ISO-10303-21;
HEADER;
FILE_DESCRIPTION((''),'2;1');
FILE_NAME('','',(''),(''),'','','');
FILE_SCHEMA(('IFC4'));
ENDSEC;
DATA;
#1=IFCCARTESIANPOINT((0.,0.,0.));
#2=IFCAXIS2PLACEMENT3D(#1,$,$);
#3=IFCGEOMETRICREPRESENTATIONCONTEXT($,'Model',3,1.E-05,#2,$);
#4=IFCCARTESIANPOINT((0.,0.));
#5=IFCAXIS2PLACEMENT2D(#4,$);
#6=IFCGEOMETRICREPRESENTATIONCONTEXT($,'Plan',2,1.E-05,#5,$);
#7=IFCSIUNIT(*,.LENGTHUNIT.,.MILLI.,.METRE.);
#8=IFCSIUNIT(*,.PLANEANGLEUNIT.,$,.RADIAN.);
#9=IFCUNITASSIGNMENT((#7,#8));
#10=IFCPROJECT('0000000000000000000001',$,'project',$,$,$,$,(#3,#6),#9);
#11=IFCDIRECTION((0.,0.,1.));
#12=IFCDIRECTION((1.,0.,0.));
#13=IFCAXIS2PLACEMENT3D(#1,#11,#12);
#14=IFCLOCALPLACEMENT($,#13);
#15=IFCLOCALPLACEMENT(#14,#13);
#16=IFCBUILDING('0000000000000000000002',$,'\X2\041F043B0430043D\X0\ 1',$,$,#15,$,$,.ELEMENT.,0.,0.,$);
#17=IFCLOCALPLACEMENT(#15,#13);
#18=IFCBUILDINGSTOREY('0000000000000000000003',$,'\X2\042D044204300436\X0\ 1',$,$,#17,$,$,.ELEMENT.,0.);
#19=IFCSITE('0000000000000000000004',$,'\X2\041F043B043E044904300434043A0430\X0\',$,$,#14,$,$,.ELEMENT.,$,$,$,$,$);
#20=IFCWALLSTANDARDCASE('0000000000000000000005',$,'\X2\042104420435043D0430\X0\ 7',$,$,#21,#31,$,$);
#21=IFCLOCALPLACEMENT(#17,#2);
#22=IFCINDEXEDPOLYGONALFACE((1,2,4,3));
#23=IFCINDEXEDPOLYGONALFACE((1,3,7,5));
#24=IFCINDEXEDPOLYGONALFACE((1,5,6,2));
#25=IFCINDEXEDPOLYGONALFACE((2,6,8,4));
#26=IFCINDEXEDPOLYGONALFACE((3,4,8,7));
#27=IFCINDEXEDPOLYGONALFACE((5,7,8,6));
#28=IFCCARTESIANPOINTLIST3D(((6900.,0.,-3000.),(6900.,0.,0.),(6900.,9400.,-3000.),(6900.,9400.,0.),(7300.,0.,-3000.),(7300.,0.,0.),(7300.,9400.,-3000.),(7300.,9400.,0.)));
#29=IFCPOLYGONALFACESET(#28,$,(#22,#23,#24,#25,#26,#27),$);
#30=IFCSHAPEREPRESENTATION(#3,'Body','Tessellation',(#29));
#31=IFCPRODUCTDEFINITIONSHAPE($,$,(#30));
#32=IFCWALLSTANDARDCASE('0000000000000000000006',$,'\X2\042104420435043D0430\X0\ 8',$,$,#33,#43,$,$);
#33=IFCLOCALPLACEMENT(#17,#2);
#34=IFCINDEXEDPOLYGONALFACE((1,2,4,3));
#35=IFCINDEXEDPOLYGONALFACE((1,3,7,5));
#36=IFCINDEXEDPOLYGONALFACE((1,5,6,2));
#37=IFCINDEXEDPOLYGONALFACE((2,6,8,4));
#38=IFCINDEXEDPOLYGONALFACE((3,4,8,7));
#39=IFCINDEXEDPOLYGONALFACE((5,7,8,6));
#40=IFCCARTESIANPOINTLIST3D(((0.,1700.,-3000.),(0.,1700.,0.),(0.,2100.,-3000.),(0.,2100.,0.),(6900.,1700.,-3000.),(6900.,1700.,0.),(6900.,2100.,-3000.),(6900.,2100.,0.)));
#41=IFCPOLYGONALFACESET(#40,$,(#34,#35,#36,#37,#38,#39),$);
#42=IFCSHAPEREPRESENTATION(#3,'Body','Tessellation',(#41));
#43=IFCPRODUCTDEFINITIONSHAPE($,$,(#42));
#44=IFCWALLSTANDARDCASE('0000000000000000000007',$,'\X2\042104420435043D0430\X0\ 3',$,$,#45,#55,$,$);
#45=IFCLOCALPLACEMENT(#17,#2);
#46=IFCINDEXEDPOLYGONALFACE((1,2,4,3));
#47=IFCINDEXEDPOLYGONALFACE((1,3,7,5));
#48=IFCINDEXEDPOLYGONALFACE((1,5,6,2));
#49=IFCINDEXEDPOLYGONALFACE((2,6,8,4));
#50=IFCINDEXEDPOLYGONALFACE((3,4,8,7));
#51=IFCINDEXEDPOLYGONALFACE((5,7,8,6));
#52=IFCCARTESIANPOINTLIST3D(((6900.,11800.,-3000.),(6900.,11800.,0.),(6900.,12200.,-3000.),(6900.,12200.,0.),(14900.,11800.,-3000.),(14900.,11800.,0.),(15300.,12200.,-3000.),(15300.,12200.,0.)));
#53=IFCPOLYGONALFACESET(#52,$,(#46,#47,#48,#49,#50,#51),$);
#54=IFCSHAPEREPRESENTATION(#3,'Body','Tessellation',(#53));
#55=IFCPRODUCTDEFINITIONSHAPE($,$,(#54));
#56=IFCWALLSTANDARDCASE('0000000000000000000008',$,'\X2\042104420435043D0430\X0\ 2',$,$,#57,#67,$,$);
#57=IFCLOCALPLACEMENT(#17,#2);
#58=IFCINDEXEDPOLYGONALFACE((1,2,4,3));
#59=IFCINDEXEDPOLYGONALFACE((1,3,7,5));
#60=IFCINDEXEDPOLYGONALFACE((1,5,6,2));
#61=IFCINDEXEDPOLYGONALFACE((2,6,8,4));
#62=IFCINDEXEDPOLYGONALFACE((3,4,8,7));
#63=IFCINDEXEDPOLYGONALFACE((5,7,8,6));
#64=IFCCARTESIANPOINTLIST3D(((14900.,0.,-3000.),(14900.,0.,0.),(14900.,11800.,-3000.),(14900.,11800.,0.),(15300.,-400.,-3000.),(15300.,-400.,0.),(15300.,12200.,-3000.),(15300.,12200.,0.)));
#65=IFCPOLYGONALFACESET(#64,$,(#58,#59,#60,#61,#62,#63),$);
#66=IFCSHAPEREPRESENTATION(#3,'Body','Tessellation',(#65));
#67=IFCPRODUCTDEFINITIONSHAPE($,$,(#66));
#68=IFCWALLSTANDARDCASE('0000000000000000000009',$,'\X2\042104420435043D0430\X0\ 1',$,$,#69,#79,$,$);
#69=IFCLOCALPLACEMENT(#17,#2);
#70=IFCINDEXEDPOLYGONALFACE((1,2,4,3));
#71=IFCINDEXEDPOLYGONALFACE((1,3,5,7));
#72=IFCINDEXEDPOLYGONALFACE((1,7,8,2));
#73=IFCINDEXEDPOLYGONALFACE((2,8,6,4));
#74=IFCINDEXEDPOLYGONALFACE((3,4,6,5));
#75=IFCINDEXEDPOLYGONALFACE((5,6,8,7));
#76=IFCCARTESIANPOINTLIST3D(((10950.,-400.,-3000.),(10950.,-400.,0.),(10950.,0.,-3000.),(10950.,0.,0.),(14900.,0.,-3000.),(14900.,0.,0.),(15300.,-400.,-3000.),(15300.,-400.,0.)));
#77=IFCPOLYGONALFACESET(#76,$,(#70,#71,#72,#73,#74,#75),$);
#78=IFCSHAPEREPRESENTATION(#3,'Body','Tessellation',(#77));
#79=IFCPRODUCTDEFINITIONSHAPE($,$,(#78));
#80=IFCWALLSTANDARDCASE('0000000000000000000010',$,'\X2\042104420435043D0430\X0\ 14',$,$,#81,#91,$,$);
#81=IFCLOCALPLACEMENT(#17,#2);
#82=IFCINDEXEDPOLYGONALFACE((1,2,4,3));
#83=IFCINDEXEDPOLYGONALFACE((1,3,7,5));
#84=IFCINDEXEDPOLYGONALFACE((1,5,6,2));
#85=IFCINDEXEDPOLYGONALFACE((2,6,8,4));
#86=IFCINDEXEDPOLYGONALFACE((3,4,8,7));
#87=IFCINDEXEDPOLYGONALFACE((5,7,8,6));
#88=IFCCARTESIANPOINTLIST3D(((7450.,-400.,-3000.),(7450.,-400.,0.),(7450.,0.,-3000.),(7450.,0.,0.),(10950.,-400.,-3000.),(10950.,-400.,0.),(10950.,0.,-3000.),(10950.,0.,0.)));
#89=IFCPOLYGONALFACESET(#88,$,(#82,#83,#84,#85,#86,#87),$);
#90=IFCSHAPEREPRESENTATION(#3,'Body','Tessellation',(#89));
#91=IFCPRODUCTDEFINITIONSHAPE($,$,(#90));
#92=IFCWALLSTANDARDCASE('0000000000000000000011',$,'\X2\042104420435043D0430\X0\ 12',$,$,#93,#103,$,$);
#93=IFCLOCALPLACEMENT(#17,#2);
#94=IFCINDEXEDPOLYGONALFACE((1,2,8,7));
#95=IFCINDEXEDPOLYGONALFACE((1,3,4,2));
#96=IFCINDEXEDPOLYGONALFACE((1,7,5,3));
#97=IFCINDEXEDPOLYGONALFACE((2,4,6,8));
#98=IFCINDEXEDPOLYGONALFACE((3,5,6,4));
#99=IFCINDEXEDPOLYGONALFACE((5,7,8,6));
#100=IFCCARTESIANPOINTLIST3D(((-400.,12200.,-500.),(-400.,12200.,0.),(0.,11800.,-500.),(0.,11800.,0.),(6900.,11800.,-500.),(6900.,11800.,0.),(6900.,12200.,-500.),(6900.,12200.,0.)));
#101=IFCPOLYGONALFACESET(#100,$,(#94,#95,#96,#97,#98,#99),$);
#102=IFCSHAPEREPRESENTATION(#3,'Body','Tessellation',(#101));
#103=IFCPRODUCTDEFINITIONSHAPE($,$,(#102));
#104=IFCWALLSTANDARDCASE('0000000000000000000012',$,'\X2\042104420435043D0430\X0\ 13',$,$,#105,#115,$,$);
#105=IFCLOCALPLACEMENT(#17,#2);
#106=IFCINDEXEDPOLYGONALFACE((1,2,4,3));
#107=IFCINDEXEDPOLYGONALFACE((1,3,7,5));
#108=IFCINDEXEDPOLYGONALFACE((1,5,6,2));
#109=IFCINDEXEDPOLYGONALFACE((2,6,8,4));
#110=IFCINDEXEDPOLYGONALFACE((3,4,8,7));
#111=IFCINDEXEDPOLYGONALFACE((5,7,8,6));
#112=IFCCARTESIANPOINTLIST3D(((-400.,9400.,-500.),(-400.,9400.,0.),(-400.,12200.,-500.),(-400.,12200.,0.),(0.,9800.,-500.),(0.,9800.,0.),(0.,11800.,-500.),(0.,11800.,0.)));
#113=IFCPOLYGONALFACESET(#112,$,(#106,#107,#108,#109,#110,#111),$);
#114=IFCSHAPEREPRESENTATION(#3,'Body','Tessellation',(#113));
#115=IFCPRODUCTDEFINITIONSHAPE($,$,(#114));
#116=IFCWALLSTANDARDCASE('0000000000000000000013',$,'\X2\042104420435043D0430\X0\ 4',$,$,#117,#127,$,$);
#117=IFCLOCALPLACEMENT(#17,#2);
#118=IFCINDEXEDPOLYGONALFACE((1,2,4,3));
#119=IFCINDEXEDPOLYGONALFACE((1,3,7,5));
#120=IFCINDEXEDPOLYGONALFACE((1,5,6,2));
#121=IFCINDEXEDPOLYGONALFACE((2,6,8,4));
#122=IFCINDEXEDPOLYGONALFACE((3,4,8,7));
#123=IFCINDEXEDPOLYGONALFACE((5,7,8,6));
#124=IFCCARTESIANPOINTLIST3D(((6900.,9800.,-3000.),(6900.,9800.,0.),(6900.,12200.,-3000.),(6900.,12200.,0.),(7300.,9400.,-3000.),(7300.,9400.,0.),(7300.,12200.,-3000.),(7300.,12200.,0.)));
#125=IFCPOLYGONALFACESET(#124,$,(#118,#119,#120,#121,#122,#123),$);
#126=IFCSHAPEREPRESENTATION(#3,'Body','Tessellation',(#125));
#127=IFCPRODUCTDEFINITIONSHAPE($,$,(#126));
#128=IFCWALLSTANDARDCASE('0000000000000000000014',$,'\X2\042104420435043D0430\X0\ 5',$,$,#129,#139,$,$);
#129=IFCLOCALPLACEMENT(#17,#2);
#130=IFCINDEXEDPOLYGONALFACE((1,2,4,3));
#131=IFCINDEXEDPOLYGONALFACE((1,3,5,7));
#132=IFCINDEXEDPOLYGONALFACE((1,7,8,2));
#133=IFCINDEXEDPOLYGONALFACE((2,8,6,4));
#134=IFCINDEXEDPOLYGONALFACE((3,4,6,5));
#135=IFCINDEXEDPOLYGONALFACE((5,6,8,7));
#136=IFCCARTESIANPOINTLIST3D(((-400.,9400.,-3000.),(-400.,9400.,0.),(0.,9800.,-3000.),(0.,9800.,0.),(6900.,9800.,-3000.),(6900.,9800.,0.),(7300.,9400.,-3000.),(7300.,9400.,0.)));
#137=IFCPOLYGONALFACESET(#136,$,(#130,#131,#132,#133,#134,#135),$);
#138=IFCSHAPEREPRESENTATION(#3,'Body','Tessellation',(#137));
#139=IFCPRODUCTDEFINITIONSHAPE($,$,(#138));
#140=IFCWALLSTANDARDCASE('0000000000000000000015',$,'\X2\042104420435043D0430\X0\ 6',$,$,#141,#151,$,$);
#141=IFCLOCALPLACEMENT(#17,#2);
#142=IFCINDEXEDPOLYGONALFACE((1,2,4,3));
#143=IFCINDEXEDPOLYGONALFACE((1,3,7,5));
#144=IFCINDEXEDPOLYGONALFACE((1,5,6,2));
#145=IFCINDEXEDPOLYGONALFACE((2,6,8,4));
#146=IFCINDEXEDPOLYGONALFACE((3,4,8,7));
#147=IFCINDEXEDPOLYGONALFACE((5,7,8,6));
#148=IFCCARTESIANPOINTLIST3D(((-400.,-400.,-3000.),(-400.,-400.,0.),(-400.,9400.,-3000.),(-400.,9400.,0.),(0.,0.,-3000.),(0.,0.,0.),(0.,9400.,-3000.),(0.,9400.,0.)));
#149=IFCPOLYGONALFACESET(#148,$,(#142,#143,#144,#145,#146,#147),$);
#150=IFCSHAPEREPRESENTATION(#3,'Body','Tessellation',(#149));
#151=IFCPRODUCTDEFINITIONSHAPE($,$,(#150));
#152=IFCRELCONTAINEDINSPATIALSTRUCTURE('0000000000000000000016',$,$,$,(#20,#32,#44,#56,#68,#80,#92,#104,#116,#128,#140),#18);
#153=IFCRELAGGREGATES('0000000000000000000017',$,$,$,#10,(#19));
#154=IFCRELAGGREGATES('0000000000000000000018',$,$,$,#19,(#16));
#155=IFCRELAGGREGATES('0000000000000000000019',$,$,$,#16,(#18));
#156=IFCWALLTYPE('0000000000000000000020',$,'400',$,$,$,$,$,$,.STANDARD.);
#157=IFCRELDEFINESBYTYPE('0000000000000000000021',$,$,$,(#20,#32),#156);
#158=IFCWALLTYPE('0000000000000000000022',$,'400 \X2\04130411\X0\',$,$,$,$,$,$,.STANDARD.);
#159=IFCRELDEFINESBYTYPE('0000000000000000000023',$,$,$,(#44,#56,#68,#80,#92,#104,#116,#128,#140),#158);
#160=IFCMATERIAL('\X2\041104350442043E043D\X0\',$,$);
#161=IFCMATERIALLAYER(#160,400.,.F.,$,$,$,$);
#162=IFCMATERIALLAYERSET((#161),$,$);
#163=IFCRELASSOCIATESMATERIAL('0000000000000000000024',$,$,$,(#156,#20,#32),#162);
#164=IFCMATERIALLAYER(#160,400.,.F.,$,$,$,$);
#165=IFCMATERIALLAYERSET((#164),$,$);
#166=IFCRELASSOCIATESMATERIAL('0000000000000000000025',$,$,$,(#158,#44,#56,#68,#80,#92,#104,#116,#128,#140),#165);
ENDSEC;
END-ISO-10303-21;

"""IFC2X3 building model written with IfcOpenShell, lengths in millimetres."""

from ifc_helpers import new_model, si_unit, frame, origin, origin_with_axes, origin_2d, place, context, project, spatial, polyline, segment, composite_curve, outline, extrude, material, layer, layer_set, layer_usage, type_object, element, save


model = new_model("IFC2X3")

# Units and contexts
model_context = context("Model", 3, precision=1e-05, world=origin())
plan_context = context("Plan", 2, precision=1e-05, world=origin_2d())
ifc_project = project(units=[si_unit("LENGTHUNIT", "METRE", prefix="MILLI"), si_unit("PLANEANGLEUNIT", "RADIAN")], contexts=[model_context, plan_context])

# Site, building, storey
site_placement = place(None, origin_with_axes())
site = spatial("IfcSite", under=ifc_project, at=site_placement, Name="Площадка", CompositionType="ELEMENT")
building_placement = place(site_placement, origin_with_axes())
building = spatial("IfcBuilding", under=site, at=building_placement, Name="План 1", CompositionType="ELEMENT", ElevationOfRefHeight=0.0, ElevationOfTerrain=0.0)
storey_placement = place(building_placement, origin_with_axes())
storey = spatial("IfcBuildingStorey", under=building, at=storey_placement, Name="Этаж 1", CompositionType="ELEMENT", Elevation=0.0)

# Walls
ifc_material = material(Name="Бетон")
ifc_layer_1 = layer(ifc_material, 400.0, ventilated=False)
ifc_layer_set_1 = layer_set([ifc_layer_1])
ifc_layer_usage_1 = layer_usage(ifc_layer_set_1, "AXIS2", "POSITIVE", -400.0)
wall_type_1 = type_object("IfcWallType", Name="400", PredefinedType="STANDARD", material=ifc_layer_set_1)
wall_1_placement = place(storey_placement, frame((6900.0, -400.0, -3000.0), z_axis=(0.0, 0.0, 1.0), x_axis=(0.0, 1.0, 0.0)))
element("IfcWallStandardCase", 1, at=wall_1_placement, inside=storey, type_object=wall_type_1, material=ifc_layer_usage_1, Name="Стена 7", context=model_context, shape_type="SweptSolid", body=[
    extrude(outline(composite_curve([segment(polyline([(400.0, 0.0), (400.0, -400.0)]), True, "CONTINUOUS"), segment(polyline([(400.0, -400.0), (9800.0, -400.0)]), True, "CONTINUOUS"), segment(polyline([(9800.0, -400.0), (9800.0, 0.0)]), True, "CONTINUOUS"), segment(polyline([(9800.0, 0.0), (400.0, 0.0)]), True, "CONTINUOUS")], self_intersect=False)), origin_with_axes(), (0.0, 0.0, 1.0), 3000.0),
])
ifc_layer_usage_2 = layer_usage(ifc_layer_set_1, "AXIS2", "POSITIVE", -400.0)
wall_2_placement = place(storey_placement, frame((-400.0, 2100.0, -3000.0), z_axis=(0.0, 0.0, 1.0), x_axis=(1.0, 0.0, 0.0)))
element("IfcWallStandardCase", 2, at=wall_2_placement, inside=storey, type_object=wall_type_1, material=ifc_layer_usage_2, Name="Стена 8", context=model_context, shape_type="SweptSolid", body=[
    extrude(outline(composite_curve([segment(polyline([(400.0, 0.0), (400.0, -400.0)]), True, "CONTINUOUS"), segment(polyline([(400.0, -400.0), (7300.0, -400.0)]), True, "CONTINUOUS"), segment(polyline([(7300.0, -400.0), (7300.0, 0.0)]), True, "CONTINUOUS"), segment(polyline([(7300.0, 0.0), (400.0, 0.0)]), True, "CONTINUOUS")], self_intersect=False)), origin_with_axes(), (0.0, 0.0, 1.0), 3000.0),
])
ifc_layer_2 = layer(ifc_material, 400.0, ventilated=False)
ifc_layer_set_2 = layer_set([ifc_layer_2])
ifc_layer_usage_3 = layer_usage(ifc_layer_set_2, "AXIS2", "POSITIVE", 0.0)
wall_type_2 = type_object("IfcWallType", Name="400 ГБ", PredefinedType="STANDARD", material=ifc_layer_set_2)
wall_3_placement = place(storey_placement, frame((15300.0, 12200.0, -3000.0), z_axis=(0.0, 0.0, 1.0), x_axis=(-1.0, 0.0, 0.0)))
element("IfcWallStandardCase", 3, at=wall_3_placement, inside=storey, type_object=wall_type_2, material=ifc_layer_usage_3, Name="Стена 3", context=model_context, shape_type="SweptSolid", body=[
    extrude(outline(composite_curve([segment(polyline([(400.0, 400.0), (0.0, 0.0)]), True, "CONTINUOUS"), segment(polyline([(0.0, 0.0), (8400.0, 0.0)]), True, "CONTINUOUS"), segment(polyline([(8400.0, 0.0), (8400.0, 400.0)]), True, "CONTINUOUS"), segment(polyline([(8400.0, 400.0), (400.0, 400.0)]), True, "CONTINUOUS")], self_intersect=False)), origin_with_axes(), (0.0, 0.0, 1.0), 3000.0),
])
ifc_layer_usage_4 = layer_usage(ifc_layer_set_2, "AXIS2", "POSITIVE", 0.0)
wall_4_placement = place(storey_placement, frame((15300.0, -400.0, -3000.0), z_axis=(0.0, 0.0, 1.0), x_axis=(0.0, 1.0, 0.0)))
element("IfcWallStandardCase", 4, at=wall_4_placement, inside=storey, type_object=wall_type_2, material=ifc_layer_usage_4, Name="Стена 2", context=model_context, shape_type="SweptSolid", body=[
    extrude(outline(composite_curve([segment(polyline([(400.0, 400.0), (0.0, 0.0)]), True, "CONTINUOUS"), segment(polyline([(0.0, 0.0), (12600.0, 0.0)]), True, "CONTINUOUS"), segment(polyline([(12600.0, 0.0), (12200.0, 400.0)]), True, "CONTINUOUS"), segment(polyline([(12200.0, 400.0), (400.0, 400.0)]), True, "CONTINUOUS")], self_intersect=False)), origin_with_axes(), (0.0, 0.0, 1.0), 3000.0),
])
ifc_layer_usage_5 = layer_usage(ifc_layer_set_2, "AXIS2", "POSITIVE", 0.0)
wall_5_placement = place(storey_placement, frame((10950.0, -400.0, -3000.0), z_axis=(0.0, 0.0, 1.0), x_axis=(1.0, 0.0, 0.0)))
element("IfcWallStandardCase", 5, at=wall_5_placement, inside=storey, type_object=wall_type_2, material=ifc_layer_usage_5, Name="Стена 1", context=model_context, shape_type="SweptSolid", body=[
    extrude(outline(composite_curve([segment(polyline([(0.0, 400.0), (0.0, 0.0)]), True, "CONTINUOUS"), segment(polyline([(0.0, 0.0), (4350.0, 0.0)]), True, "CONTINUOUS"), segment(polyline([(4350.0, 0.0), (3950.0, 400.0)]), True, "CONTINUOUS"), segment(polyline([(3950.0, 400.0), (0.0, 400.0)]), True, "CONTINUOUS")], self_intersect=False)), origin_with_axes(), (0.0, 0.0, 1.0), 3000.0),
])
ifc_layer_usage_6 = layer_usage(ifc_layer_set_2, "AXIS2", "POSITIVE", 0.0)
wall_6_placement = place(storey_placement, frame((7450.0, -400.0, -3000.0), z_axis=(0.0, 0.0, 1.0), x_axis=(1.0, 0.0, 0.0)))
element("IfcWallStandardCase", 6, at=wall_6_placement, inside=storey, type_object=wall_type_2, material=ifc_layer_usage_6, Name="Стена 14", context=model_context, shape_type="SweptSolid", body=[
    extrude(outline(composite_curve([segment(polyline([(0.0, 400.0), (0.0, 0.0)]), True, "CONTINUOUS"), segment(polyline([(0.0, 0.0), (3500.0, 0.0)]), True, "CONTINUOUS"), segment(polyline([(3500.0, 0.0), (3500.0, 400.0)]), True, "CONTINUOUS"), segment(polyline([(3500.0, 400.0), (0.0, 400.0)]), True, "CONTINUOUS")], self_intersect=False)), origin_with_axes(), (0.0, 0.0, 1.0), 3000.0),
])
ifc_layer_usage_7 = layer_usage(ifc_layer_set_2, "AXIS2", "POSITIVE", 0.0)
wall_7_placement = place(storey_placement, frame((6900.0, 12200.0, -500.0), z_axis=(0.0, 0.0, 1.0), x_axis=(-1.0, 0.0, 0.0)))
element("IfcWallStandardCase", 7, at=wall_7_placement, inside=storey, type_object=wall_type_2, material=ifc_layer_usage_7, Name="Стена 12", context=model_context, shape_type="SweptSolid", body=[
    extrude(outline(composite_curve([segment(polyline([(0.0, 400.0), (0.0, 0.0)]), True, "CONTINUOUS"), segment(polyline([(0.0, 0.0), (7300.0, 0.0)]), True, "CONTINUOUS"), segment(polyline([(7300.0, 0.0), (6900.0, 400.0)]), True, "CONTINUOUS"), segment(polyline([(6900.0, 400.0), (0.0, 400.0)]), True, "CONTINUOUS")], self_intersect=False)), origin_with_axes(), (0.0, 0.0, 1.0), 500.0),
])
ifc_layer_usage_8 = layer_usage(ifc_layer_set_2, "AXIS2", "POSITIVE", 0.0)
wall_8_placement = place(storey_placement, frame((-400.0, 12200.0, -500.0), z_axis=(0.0, 0.0, 1.0), x_axis=(0.0, -1.0, 0.0)))
element("IfcWallStandardCase", 8, at=wall_8_placement, inside=storey, type_object=wall_type_2, material=ifc_layer_usage_8, Name="Стена 13", context=model_context, shape_type="SweptSolid", body=[
    extrude(outline(composite_curve([segment(polyline([(400.0, 400.0), (0.0, 0.0)]), True, "CONTINUOUS"), segment(polyline([(0.0, 0.0), (2800.0, 0.0)]), True, "CONTINUOUS"), segment(polyline([(2800.0, 0.0), (2400.0, 400.0)]), True, "CONTINUOUS"), segment(polyline([(2400.0, 400.0), (400.0, 400.0)]), True, "CONTINUOUS")], self_intersect=False)), origin_with_axes(), (0.0, 0.0, 1.0), 500.0),
])
ifc_layer_usage_9 = layer_usage(ifc_layer_set_2, "AXIS2", "POSITIVE", 0.0)
wall_9_placement = place(storey_placement, frame((6900.0, 12200.0, -3000.0), z_axis=(0.0, 0.0, 1.0), x_axis=(0.0, -1.0, 0.0)))
element("IfcWallStandardCase", 9, at=wall_9_placement, inside=storey, type_object=wall_type_2, material=ifc_layer_usage_9, Name="Стена 4", context=model_context, shape_type="SweptSolid", body=[
    extrude(outline(composite_curve([segment(polyline([(0.0, 400.0), (0.0, 0.0)]), True, "CONTINUOUS"), segment(polyline([(0.0, 0.0), (2400.0, 0.0)]), True, "CONTINUOUS"), segment(polyline([(2400.0, 0.0), (2800.0, 400.0)]), True, "CONTINUOUS"), segment(polyline([(2800.0, 400.0), (0.0, 400.0)]), True, "CONTINUOUS")], self_intersect=False)), origin_with_axes(), (0.0, 0.0, 1.0), 3000.0),
])
ifc_layer_usage_10 = layer_usage(ifc_layer_set_2, "AXIS2", "POSITIVE", 0.0)
wall_10_placement = place(storey_placement, frame((6900.0, 9800.0, -3000.0), z_axis=(0.0, 0.0, 1.0), x_axis=(-1.0, 0.0, 0.0)))
element("IfcWallStandardCase", 10, at=wall_10_placement, inside=storey, type_object=wall_type_2, material=ifc_layer_usage_10, Name="Стена 5", context=model_context, shape_type="SweptSolid", body=[
    extrude(outline(composite_curve([segment(polyline([(-400.0, 400.0), (0.0, 0.0)]), True, "CONTINUOUS"), segment(polyline([(0.0, 0.0), (6900.0, 0.0)]), True, "CONTINUOUS"), segment(polyline([(6900.0, 0.0), (7300.0, 400.0)]), True, "CONTINUOUS"), segment(polyline([(7300.0, 400.0), (-400.0, 400.0)]), True, "CONTINUOUS")], self_intersect=False)), origin_with_axes(), (0.0, 0.0, 1.0), 3000.0),
])
ifc_layer_usage_11 = layer_usage(ifc_layer_set_2, "AXIS2", "POSITIVE", 0.0)
wall_11_placement = place(storey_placement, frame((-400.0, 9800.0, -3000.0), z_axis=(0.0, 0.0, 1.0), x_axis=(0.0, -1.0, 0.0)))
element("IfcWallStandardCase", 11, at=wall_11_placement, inside=storey, type_object=wall_type_2, material=ifc_layer_usage_11, Name="Стена 6", context=model_context, shape_type="SweptSolid", body=[
    extrude(outline(composite_curve([segment(polyline([(400.0, 400.0), (400.0, 0.0)]), True, "CONTINUOUS"), segment(polyline([(400.0, 0.0), (10200.0, 0.0)]), True, "CONTINUOUS"), segment(polyline([(10200.0, 0.0), (9800.0, 400.0)]), True, "CONTINUOUS"), segment(polyline([(9800.0, 400.0), (400.0, 400.0)]), True, "CONTINUOUS")], self_intersect=False)), origin_with_axes(), (0.0, 0.0, 1.0), 3000.0),
])

save(model, "model.ifc")
